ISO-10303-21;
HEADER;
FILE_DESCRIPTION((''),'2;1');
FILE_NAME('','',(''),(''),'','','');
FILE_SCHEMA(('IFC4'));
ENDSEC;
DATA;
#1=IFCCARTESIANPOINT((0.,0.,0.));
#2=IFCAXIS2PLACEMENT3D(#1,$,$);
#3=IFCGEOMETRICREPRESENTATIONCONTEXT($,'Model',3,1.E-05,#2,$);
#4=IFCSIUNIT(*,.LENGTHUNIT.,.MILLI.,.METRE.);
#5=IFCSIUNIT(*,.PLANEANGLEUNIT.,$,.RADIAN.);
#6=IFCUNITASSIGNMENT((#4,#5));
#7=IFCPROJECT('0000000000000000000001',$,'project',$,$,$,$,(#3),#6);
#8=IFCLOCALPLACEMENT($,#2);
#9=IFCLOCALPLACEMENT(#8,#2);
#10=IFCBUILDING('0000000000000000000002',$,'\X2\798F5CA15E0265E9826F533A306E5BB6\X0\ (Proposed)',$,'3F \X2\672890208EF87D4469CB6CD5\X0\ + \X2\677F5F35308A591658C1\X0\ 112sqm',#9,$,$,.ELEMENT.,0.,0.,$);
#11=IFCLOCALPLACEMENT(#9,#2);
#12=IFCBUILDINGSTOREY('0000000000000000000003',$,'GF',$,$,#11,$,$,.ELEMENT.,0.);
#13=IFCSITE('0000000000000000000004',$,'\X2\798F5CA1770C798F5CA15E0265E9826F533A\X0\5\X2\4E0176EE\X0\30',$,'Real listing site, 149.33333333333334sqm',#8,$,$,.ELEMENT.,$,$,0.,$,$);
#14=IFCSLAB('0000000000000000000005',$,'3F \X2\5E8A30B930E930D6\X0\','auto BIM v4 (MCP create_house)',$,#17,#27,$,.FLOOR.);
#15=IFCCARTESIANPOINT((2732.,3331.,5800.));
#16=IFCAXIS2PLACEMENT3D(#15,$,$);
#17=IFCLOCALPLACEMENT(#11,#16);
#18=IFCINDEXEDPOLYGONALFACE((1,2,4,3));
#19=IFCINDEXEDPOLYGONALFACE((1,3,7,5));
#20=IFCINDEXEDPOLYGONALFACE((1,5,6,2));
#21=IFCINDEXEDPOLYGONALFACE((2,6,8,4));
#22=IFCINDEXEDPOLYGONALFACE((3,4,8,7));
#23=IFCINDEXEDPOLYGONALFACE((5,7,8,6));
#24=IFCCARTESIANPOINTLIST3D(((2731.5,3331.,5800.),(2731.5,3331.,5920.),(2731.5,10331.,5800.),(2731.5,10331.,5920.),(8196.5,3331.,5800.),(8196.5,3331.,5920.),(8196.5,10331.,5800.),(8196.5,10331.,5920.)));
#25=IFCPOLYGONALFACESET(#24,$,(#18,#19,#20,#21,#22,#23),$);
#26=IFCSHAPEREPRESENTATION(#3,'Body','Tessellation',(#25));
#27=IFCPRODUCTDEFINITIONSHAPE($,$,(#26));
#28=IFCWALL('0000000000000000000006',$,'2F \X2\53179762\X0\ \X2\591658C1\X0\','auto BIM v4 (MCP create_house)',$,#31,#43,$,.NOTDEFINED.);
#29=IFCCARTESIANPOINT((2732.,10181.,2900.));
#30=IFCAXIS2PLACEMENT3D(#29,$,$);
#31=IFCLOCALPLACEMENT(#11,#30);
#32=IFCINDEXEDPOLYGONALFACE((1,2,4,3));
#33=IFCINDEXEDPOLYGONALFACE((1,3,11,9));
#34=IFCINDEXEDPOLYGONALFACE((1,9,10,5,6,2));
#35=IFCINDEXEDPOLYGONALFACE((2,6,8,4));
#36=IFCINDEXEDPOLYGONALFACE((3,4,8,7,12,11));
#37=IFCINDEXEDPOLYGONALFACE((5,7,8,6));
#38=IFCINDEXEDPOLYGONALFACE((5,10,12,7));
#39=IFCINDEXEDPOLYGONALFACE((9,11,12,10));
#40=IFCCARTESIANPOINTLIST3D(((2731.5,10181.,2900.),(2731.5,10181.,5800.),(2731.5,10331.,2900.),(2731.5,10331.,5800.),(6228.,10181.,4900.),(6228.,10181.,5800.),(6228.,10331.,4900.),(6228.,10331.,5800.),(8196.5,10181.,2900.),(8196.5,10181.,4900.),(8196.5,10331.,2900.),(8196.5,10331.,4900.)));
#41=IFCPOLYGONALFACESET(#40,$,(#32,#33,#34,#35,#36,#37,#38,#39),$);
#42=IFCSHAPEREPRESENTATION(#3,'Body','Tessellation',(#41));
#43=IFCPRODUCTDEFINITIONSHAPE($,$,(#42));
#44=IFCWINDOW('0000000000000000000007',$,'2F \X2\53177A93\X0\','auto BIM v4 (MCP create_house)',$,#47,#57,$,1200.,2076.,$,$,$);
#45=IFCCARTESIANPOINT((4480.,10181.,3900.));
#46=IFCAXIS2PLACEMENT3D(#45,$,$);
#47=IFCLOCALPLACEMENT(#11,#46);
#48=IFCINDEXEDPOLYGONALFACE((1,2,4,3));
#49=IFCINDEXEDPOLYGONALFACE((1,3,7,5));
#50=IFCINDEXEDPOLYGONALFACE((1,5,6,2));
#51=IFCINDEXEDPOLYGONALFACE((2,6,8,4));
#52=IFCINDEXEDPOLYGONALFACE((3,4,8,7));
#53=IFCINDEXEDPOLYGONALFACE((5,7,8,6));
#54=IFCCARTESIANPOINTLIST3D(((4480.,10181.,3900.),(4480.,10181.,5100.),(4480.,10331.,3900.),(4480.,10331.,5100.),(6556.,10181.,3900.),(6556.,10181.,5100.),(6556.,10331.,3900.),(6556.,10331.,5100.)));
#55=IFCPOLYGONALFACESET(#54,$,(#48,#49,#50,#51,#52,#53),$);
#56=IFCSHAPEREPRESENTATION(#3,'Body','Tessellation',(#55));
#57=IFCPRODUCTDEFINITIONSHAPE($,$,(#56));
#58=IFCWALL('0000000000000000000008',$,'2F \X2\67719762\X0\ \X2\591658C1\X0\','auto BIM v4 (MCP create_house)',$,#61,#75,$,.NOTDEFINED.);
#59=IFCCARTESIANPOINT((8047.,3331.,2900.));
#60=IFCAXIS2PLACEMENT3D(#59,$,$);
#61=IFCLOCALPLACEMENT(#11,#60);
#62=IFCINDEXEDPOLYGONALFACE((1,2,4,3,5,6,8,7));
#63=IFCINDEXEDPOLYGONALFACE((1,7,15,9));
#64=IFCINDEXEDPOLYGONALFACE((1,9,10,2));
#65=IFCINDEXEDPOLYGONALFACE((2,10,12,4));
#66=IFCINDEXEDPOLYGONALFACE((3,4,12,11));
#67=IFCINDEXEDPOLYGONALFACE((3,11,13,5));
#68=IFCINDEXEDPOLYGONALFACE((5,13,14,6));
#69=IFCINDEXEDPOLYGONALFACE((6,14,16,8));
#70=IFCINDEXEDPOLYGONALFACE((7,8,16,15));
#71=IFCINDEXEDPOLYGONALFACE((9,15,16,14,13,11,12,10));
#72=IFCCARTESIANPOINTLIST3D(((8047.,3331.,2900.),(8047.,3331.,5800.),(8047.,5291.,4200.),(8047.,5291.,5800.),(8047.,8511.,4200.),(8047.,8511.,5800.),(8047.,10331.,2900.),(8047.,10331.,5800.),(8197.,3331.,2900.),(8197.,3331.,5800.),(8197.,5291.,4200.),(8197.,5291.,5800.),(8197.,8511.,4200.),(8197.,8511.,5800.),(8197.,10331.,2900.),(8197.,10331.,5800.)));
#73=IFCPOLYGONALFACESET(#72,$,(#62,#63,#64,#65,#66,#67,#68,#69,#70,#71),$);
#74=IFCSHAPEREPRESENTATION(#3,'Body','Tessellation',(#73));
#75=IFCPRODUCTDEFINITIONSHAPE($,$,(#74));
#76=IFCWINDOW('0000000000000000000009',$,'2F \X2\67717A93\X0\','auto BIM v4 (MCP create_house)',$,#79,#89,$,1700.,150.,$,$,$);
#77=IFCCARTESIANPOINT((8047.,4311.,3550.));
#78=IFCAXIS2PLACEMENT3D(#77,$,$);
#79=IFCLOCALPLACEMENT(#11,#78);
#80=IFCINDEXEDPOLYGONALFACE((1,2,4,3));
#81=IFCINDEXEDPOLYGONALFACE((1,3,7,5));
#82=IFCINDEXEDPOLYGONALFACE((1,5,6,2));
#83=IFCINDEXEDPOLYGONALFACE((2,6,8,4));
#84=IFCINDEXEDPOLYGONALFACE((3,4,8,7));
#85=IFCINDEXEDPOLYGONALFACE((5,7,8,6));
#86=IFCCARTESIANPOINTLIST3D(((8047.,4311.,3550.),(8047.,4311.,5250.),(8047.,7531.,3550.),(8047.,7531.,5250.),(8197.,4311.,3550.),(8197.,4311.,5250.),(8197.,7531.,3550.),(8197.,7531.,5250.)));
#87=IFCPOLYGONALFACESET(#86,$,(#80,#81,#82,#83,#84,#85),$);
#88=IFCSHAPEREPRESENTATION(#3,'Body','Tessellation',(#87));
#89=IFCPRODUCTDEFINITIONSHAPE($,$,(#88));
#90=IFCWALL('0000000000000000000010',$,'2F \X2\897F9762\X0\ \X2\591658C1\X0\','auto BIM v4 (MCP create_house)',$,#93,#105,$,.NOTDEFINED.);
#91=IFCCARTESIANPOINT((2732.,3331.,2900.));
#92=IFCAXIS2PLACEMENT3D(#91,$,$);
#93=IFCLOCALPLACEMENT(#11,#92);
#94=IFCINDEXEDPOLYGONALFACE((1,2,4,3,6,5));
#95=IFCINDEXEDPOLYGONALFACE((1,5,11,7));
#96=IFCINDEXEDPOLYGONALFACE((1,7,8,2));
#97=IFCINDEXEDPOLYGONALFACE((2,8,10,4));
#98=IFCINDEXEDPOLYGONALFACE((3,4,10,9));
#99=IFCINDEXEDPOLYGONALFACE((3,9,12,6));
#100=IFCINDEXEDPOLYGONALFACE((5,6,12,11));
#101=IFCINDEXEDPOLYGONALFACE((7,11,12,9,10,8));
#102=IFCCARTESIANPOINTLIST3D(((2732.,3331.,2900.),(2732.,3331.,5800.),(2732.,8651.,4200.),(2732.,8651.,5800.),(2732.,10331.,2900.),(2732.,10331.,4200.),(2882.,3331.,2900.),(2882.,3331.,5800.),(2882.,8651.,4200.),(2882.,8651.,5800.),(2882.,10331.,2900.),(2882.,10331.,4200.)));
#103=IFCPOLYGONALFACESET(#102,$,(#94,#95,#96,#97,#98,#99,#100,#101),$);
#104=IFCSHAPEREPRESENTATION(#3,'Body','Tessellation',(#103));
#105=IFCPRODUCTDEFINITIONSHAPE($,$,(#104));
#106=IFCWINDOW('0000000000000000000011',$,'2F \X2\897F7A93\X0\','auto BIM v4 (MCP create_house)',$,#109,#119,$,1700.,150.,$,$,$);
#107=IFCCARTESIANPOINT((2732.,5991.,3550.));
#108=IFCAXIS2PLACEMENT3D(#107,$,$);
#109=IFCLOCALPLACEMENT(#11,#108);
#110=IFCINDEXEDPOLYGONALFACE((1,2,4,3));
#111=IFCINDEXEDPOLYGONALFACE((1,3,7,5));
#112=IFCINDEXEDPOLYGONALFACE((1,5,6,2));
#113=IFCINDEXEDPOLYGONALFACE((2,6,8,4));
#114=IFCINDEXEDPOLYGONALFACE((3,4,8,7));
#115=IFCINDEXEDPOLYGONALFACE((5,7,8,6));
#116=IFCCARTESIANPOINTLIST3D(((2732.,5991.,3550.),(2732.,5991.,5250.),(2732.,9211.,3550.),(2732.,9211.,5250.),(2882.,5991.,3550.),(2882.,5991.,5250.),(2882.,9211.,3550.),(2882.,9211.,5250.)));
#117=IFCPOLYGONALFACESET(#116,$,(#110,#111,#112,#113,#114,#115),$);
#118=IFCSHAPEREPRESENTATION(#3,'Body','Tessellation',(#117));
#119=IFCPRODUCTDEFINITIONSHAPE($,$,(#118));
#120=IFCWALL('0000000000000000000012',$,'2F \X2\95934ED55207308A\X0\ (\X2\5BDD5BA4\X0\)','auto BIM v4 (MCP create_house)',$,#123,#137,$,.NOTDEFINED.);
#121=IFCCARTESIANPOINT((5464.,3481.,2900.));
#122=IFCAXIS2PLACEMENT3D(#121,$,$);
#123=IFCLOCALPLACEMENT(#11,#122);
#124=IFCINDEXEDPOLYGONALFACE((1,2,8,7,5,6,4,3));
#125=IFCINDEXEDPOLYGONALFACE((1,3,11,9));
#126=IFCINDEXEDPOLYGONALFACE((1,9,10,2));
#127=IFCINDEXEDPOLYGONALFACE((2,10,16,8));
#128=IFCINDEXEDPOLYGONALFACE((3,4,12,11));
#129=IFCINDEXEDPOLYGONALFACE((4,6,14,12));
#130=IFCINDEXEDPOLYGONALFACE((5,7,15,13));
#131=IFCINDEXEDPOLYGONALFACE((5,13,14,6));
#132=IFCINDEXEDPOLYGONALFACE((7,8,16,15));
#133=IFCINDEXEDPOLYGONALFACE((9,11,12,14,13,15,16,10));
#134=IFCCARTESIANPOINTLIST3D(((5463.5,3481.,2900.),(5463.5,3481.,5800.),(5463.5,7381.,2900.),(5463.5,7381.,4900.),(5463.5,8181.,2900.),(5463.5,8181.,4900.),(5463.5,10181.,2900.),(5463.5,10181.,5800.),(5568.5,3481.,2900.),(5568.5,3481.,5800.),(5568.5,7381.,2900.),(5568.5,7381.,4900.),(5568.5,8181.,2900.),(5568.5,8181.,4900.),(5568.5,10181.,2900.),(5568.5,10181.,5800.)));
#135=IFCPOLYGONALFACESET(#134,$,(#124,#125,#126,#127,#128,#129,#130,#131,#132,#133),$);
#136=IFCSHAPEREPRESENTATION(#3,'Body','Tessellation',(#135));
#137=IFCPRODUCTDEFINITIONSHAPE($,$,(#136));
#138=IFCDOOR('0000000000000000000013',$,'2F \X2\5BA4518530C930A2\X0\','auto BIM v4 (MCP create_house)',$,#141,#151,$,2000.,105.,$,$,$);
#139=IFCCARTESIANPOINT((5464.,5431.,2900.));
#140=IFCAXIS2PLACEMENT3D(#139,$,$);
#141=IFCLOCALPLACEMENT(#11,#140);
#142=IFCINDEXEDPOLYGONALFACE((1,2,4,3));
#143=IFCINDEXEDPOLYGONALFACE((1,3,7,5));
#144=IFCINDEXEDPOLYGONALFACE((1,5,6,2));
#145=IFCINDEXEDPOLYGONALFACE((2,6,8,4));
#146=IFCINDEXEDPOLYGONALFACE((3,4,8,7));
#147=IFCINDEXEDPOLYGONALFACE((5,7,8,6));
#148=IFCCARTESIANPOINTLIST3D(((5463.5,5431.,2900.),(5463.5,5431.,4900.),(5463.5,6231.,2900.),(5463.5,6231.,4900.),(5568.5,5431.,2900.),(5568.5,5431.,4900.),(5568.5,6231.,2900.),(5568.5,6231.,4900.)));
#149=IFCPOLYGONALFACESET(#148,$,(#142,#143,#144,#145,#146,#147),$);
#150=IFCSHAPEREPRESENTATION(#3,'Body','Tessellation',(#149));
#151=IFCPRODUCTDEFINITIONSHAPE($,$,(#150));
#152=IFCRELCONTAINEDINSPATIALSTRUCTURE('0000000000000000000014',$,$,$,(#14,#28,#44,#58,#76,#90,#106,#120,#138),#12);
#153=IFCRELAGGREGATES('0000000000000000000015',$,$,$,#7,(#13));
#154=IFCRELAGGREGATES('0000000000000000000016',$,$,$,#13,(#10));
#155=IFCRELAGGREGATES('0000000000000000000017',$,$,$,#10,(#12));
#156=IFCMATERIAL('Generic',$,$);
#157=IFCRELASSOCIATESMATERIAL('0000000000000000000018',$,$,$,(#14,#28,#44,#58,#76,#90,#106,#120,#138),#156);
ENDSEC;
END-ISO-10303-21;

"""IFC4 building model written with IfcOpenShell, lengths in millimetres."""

from ifc_helpers import new_model, si_unit, frame, frame_2d, origin, place, context, project, spatial, rectangle, extrude, material, element, fill, save


model = new_model("IFC4")

# Units and contexts
model_context = context("Model", 3, precision=1e-05, world=origin())
ifc_project = project(units=[si_unit("LENGTHUNIT", "METRE", prefix="MILLI"), si_unit("PLANEANGLEUNIT", "RADIAN")], contexts=[model_context])

# Site, building, storey
site_placement = place(None, origin())
site = spatial("IfcSite", under=ifc_project, at=site_placement, Name="福岡県福岡市早良区5丁目30", ObjectType="Real listing site, 149.33333333333334sqm", CompositionType="ELEMENT", RefElevation=0.0)
building_placement = place(site_placement, origin())
building = spatial("IfcBuilding", under=site, at=building_placement, Name="福岡市早良区の家 (Proposed)", ObjectType="3F 木造軸組構法 + 板張り外壁 112sqm", CompositionType="ELEMENT", ElevationOfRefHeight=0.0, ElevationOfTerrain=0.0)
storey_placement = place(building_placement, origin())
storey = spatial("IfcBuildingStorey", under=building, at=storey_placement, Name="GF", CompositionType="ELEMENT", Elevation=0.0)

# Slab
ifc_material = material(Name="Generic")
slab_placement = place(storey_placement, frame((2732.0, 3331.0, 5800.0)))
element("IfcSlab", 1, at=slab_placement, inside=storey, material=ifc_material, Name="3F 床スラブ", Description="auto BIM v4 (MCP create_house)", PredefinedType="FLOOR", context=model_context, shape_type="SweptSolid", body=[
    extrude(rectangle(XDim=5465.0, YDim=7000.0, at=frame_2d((2732.0, 3500.0))), frame((2732.0, 3331.0, 5800.0)), (0.0, 0.0, 1.0), 120.0),
])

# Walls, openings, windows
wall_1_placement = place(storey_placement, frame((2732.0, 10181.0, 2900.0)))
wall_1 = element("IfcWall", 2, at=wall_1_placement, inside=storey, material=ifc_material, Name="2F 北面 外壁", Description="auto BIM v4 (MCP create_house)", PredefinedType="NOTDEFINED", context=model_context, shape_type="SweptSolid", body=[
    extrude(rectangle(XDim=5465.0, YDim=150.0, at=frame_2d((2732.0, 75.0))), frame((2732.0, 10181.0, 2900.0)), (0.0, 0.0, 1.0), 2900.0),
])
opening_1_placement = place(storey_placement, frame((4480.0, 10181.0, 3900.0)))
opening_1 = element("IfcOpeningElement", 3, at=opening_1_placement, cuts=wall_1, PredefinedType="NOTDEFINED", context=model_context, shape_type="SweptSolid", body=[
    extrude(rectangle(XDim=2076.0, YDim=150.0, at=frame_2d((1038.0, 75.0))), frame((4480.0, 10181.0, 3900.0)), (0.0, 0.0, 1.0), 1200.0),
])
window_1_placement = place(storey_placement, frame((4480.0, 10181.0, 3900.0)))
window_1 = element("IfcWindow", 4, at=window_1_placement, inside=storey, material=ifc_material, Name="2F 北窓", Description="auto BIM v4 (MCP create_house)", OverallHeight=1200.0, OverallWidth=2076.0, context=model_context, shape_type="SweptSolid", body=[
    extrude(rectangle(XDim=2076.0, YDim=150.0, at=frame_2d((1038.0, 75.0))), frame((4480.0, 10181.0, 3900.0)), (0.0, 0.0, 1.0), 1200.0),
])
fill(opening_1, window_1)
wall_2_placement = place(storey_placement, frame((8047.0, 3331.0, 2900.0)))
wall_2 = element("IfcWall", 5, at=wall_2_placement, inside=storey, material=ifc_material, Name="2F 東面 外壁", Description="auto BIM v4 (MCP create_house)", PredefinedType="NOTDEFINED", context=model_context, shape_type="SweptSolid", body=[
    extrude(rectangle(XDim=150.0, YDim=7000.0, at=frame_2d((75.0, 3500.0))), frame((8047.0, 3331.0, 2900.0)), (0.0, 0.0, 1.0), 2900.0),
])
opening_2_placement = place(storey_placement, frame((8047.0, 4311.0, 3550.0)))
opening_2 = element("IfcOpeningElement", 6, at=opening_2_placement, cuts=wall_2, PredefinedType="NOTDEFINED", context=model_context, shape_type="SweptSolid", body=[
    extrude(rectangle(XDim=150.0, YDim=3220.0, at=frame_2d((75.0, 1610.0))), frame((8047.0, 4311.0, 3550.0)), (0.0, 0.0, 1.0), 1700.0),
])
window_2_placement = place(storey_placement, frame((8047.0, 4311.0, 3550.0)))
window_2 = element("IfcWindow", 7, at=window_2_placement, inside=storey, material=ifc_material, Name="2F 東窓", Description="auto BIM v4 (MCP create_house)", OverallHeight=1700.0, OverallWidth=150.0, context=model_context, shape_type="SweptSolid", body=[
    extrude(rectangle(XDim=150.0, YDim=3220.0, at=frame_2d((75.0, 1610.0))), frame((8047.0, 4311.0, 3550.0)), (0.0, 0.0, 1.0), 1700.0),
])
fill(opening_2, window_2)
wall_3_placement = place(storey_placement, frame((2732.0, 3331.0, 2900.0)))
wall_3 = element("IfcWall", 8, at=wall_3_placement, inside=storey, material=ifc_material, Name="2F 西面 外壁", Description="auto BIM v4 (MCP create_house)", PredefinedType="NOTDEFINED", context=model_context, shape_type="SweptSolid", body=[
    extrude(rectangle(XDim=150.0, YDim=7000.0, at=frame_2d((75.0, 3500.0))), frame((2732.0, 3331.0, 2900.0)), (0.0, 0.0, 1.0), 2900.0),
])
opening_3_placement = place(storey_placement, frame((2732.0, 5991.0, 3550.0)))
opening_3 = element("IfcOpeningElement", 9, at=opening_3_placement, cuts=wall_3, PredefinedType="NOTDEFINED", context=model_context, shape_type="SweptSolid", body=[
    extrude(rectangle(XDim=150.0, YDim=3220.0, at=frame_2d((75.0, 1610.0))), frame((2732.0, 5991.0, 3550.0)), (0.0, 0.0, 1.0), 1700.0),
])
window_3_placement = place(storey_placement, frame((2732.0, 5991.0, 3550.0)))
window_3 = element("IfcWindow", 10, at=window_3_placement, inside=storey, material=ifc_material, Name="2F 西窓", Description="auto BIM v4 (MCP create_house)", OverallHeight=1700.0, OverallWidth=150.0, context=model_context, shape_type="SweptSolid", body=[
    extrude(rectangle(XDim=150.0, YDim=3220.0, at=frame_2d((75.0, 1610.0))), frame((2732.0, 5991.0, 3550.0)), (0.0, 0.0, 1.0), 1700.0),
])
fill(opening_3, window_3)

# Wall, opening, door
wall_4_placement = place(storey_placement, frame((5464.0, 3481.0, 2900.0)))
wall_4 = element("IfcWall", 11, at=wall_4_placement, inside=storey, material=ifc_material, Name="2F 間仕切り (寝室)", Description="auto BIM v4 (MCP create_house)", PredefinedType="NOTDEFINED", context=model_context, shape_type="SweptSolid", body=[
    extrude(rectangle(XDim=105.0, YDim=6700.0, at=frame_2d((52.0, 3350.0))), frame((5464.0, 3481.0, 2900.0)), (0.0, 0.0, 1.0), 2900.0),
])
opening_4_placement = place(storey_placement, frame((5464.0, 5431.0, 2900.0)))
opening_4 = element("IfcOpeningElement", 12, at=opening_4_placement, cuts=wall_4, PredefinedType="NOTDEFINED", context=model_context, shape_type="SweptSolid", body=[
    extrude(rectangle(XDim=105.0, YDim=800.0, at=frame_2d((52.0, 400.0))), frame((5464.0, 5431.0, 2900.0)), (0.0, 0.0, 1.0), 2000.0),
])
door_1_placement = place(storey_placement, frame((5464.0, 5431.0, 2900.0)))
door_1 = element("IfcDoor", 13, at=door_1_placement, inside=storey, material=ifc_material, Name="2F 室内ドア", Description="auto BIM v4 (MCP create_house)", OverallHeight=2000.0, OverallWidth=105.0, context=model_context, shape_type="SweptSolid", body=[
    extrude(rectangle(XDim=105.0, YDim=800.0, at=frame_2d((52.0, 400.0))), frame((5464.0, 5431.0, 2900.0)), (0.0, 0.0, 1.0), 2000.0),
])
fill(opening_4, door_1)

save(model, "model.ifc")
